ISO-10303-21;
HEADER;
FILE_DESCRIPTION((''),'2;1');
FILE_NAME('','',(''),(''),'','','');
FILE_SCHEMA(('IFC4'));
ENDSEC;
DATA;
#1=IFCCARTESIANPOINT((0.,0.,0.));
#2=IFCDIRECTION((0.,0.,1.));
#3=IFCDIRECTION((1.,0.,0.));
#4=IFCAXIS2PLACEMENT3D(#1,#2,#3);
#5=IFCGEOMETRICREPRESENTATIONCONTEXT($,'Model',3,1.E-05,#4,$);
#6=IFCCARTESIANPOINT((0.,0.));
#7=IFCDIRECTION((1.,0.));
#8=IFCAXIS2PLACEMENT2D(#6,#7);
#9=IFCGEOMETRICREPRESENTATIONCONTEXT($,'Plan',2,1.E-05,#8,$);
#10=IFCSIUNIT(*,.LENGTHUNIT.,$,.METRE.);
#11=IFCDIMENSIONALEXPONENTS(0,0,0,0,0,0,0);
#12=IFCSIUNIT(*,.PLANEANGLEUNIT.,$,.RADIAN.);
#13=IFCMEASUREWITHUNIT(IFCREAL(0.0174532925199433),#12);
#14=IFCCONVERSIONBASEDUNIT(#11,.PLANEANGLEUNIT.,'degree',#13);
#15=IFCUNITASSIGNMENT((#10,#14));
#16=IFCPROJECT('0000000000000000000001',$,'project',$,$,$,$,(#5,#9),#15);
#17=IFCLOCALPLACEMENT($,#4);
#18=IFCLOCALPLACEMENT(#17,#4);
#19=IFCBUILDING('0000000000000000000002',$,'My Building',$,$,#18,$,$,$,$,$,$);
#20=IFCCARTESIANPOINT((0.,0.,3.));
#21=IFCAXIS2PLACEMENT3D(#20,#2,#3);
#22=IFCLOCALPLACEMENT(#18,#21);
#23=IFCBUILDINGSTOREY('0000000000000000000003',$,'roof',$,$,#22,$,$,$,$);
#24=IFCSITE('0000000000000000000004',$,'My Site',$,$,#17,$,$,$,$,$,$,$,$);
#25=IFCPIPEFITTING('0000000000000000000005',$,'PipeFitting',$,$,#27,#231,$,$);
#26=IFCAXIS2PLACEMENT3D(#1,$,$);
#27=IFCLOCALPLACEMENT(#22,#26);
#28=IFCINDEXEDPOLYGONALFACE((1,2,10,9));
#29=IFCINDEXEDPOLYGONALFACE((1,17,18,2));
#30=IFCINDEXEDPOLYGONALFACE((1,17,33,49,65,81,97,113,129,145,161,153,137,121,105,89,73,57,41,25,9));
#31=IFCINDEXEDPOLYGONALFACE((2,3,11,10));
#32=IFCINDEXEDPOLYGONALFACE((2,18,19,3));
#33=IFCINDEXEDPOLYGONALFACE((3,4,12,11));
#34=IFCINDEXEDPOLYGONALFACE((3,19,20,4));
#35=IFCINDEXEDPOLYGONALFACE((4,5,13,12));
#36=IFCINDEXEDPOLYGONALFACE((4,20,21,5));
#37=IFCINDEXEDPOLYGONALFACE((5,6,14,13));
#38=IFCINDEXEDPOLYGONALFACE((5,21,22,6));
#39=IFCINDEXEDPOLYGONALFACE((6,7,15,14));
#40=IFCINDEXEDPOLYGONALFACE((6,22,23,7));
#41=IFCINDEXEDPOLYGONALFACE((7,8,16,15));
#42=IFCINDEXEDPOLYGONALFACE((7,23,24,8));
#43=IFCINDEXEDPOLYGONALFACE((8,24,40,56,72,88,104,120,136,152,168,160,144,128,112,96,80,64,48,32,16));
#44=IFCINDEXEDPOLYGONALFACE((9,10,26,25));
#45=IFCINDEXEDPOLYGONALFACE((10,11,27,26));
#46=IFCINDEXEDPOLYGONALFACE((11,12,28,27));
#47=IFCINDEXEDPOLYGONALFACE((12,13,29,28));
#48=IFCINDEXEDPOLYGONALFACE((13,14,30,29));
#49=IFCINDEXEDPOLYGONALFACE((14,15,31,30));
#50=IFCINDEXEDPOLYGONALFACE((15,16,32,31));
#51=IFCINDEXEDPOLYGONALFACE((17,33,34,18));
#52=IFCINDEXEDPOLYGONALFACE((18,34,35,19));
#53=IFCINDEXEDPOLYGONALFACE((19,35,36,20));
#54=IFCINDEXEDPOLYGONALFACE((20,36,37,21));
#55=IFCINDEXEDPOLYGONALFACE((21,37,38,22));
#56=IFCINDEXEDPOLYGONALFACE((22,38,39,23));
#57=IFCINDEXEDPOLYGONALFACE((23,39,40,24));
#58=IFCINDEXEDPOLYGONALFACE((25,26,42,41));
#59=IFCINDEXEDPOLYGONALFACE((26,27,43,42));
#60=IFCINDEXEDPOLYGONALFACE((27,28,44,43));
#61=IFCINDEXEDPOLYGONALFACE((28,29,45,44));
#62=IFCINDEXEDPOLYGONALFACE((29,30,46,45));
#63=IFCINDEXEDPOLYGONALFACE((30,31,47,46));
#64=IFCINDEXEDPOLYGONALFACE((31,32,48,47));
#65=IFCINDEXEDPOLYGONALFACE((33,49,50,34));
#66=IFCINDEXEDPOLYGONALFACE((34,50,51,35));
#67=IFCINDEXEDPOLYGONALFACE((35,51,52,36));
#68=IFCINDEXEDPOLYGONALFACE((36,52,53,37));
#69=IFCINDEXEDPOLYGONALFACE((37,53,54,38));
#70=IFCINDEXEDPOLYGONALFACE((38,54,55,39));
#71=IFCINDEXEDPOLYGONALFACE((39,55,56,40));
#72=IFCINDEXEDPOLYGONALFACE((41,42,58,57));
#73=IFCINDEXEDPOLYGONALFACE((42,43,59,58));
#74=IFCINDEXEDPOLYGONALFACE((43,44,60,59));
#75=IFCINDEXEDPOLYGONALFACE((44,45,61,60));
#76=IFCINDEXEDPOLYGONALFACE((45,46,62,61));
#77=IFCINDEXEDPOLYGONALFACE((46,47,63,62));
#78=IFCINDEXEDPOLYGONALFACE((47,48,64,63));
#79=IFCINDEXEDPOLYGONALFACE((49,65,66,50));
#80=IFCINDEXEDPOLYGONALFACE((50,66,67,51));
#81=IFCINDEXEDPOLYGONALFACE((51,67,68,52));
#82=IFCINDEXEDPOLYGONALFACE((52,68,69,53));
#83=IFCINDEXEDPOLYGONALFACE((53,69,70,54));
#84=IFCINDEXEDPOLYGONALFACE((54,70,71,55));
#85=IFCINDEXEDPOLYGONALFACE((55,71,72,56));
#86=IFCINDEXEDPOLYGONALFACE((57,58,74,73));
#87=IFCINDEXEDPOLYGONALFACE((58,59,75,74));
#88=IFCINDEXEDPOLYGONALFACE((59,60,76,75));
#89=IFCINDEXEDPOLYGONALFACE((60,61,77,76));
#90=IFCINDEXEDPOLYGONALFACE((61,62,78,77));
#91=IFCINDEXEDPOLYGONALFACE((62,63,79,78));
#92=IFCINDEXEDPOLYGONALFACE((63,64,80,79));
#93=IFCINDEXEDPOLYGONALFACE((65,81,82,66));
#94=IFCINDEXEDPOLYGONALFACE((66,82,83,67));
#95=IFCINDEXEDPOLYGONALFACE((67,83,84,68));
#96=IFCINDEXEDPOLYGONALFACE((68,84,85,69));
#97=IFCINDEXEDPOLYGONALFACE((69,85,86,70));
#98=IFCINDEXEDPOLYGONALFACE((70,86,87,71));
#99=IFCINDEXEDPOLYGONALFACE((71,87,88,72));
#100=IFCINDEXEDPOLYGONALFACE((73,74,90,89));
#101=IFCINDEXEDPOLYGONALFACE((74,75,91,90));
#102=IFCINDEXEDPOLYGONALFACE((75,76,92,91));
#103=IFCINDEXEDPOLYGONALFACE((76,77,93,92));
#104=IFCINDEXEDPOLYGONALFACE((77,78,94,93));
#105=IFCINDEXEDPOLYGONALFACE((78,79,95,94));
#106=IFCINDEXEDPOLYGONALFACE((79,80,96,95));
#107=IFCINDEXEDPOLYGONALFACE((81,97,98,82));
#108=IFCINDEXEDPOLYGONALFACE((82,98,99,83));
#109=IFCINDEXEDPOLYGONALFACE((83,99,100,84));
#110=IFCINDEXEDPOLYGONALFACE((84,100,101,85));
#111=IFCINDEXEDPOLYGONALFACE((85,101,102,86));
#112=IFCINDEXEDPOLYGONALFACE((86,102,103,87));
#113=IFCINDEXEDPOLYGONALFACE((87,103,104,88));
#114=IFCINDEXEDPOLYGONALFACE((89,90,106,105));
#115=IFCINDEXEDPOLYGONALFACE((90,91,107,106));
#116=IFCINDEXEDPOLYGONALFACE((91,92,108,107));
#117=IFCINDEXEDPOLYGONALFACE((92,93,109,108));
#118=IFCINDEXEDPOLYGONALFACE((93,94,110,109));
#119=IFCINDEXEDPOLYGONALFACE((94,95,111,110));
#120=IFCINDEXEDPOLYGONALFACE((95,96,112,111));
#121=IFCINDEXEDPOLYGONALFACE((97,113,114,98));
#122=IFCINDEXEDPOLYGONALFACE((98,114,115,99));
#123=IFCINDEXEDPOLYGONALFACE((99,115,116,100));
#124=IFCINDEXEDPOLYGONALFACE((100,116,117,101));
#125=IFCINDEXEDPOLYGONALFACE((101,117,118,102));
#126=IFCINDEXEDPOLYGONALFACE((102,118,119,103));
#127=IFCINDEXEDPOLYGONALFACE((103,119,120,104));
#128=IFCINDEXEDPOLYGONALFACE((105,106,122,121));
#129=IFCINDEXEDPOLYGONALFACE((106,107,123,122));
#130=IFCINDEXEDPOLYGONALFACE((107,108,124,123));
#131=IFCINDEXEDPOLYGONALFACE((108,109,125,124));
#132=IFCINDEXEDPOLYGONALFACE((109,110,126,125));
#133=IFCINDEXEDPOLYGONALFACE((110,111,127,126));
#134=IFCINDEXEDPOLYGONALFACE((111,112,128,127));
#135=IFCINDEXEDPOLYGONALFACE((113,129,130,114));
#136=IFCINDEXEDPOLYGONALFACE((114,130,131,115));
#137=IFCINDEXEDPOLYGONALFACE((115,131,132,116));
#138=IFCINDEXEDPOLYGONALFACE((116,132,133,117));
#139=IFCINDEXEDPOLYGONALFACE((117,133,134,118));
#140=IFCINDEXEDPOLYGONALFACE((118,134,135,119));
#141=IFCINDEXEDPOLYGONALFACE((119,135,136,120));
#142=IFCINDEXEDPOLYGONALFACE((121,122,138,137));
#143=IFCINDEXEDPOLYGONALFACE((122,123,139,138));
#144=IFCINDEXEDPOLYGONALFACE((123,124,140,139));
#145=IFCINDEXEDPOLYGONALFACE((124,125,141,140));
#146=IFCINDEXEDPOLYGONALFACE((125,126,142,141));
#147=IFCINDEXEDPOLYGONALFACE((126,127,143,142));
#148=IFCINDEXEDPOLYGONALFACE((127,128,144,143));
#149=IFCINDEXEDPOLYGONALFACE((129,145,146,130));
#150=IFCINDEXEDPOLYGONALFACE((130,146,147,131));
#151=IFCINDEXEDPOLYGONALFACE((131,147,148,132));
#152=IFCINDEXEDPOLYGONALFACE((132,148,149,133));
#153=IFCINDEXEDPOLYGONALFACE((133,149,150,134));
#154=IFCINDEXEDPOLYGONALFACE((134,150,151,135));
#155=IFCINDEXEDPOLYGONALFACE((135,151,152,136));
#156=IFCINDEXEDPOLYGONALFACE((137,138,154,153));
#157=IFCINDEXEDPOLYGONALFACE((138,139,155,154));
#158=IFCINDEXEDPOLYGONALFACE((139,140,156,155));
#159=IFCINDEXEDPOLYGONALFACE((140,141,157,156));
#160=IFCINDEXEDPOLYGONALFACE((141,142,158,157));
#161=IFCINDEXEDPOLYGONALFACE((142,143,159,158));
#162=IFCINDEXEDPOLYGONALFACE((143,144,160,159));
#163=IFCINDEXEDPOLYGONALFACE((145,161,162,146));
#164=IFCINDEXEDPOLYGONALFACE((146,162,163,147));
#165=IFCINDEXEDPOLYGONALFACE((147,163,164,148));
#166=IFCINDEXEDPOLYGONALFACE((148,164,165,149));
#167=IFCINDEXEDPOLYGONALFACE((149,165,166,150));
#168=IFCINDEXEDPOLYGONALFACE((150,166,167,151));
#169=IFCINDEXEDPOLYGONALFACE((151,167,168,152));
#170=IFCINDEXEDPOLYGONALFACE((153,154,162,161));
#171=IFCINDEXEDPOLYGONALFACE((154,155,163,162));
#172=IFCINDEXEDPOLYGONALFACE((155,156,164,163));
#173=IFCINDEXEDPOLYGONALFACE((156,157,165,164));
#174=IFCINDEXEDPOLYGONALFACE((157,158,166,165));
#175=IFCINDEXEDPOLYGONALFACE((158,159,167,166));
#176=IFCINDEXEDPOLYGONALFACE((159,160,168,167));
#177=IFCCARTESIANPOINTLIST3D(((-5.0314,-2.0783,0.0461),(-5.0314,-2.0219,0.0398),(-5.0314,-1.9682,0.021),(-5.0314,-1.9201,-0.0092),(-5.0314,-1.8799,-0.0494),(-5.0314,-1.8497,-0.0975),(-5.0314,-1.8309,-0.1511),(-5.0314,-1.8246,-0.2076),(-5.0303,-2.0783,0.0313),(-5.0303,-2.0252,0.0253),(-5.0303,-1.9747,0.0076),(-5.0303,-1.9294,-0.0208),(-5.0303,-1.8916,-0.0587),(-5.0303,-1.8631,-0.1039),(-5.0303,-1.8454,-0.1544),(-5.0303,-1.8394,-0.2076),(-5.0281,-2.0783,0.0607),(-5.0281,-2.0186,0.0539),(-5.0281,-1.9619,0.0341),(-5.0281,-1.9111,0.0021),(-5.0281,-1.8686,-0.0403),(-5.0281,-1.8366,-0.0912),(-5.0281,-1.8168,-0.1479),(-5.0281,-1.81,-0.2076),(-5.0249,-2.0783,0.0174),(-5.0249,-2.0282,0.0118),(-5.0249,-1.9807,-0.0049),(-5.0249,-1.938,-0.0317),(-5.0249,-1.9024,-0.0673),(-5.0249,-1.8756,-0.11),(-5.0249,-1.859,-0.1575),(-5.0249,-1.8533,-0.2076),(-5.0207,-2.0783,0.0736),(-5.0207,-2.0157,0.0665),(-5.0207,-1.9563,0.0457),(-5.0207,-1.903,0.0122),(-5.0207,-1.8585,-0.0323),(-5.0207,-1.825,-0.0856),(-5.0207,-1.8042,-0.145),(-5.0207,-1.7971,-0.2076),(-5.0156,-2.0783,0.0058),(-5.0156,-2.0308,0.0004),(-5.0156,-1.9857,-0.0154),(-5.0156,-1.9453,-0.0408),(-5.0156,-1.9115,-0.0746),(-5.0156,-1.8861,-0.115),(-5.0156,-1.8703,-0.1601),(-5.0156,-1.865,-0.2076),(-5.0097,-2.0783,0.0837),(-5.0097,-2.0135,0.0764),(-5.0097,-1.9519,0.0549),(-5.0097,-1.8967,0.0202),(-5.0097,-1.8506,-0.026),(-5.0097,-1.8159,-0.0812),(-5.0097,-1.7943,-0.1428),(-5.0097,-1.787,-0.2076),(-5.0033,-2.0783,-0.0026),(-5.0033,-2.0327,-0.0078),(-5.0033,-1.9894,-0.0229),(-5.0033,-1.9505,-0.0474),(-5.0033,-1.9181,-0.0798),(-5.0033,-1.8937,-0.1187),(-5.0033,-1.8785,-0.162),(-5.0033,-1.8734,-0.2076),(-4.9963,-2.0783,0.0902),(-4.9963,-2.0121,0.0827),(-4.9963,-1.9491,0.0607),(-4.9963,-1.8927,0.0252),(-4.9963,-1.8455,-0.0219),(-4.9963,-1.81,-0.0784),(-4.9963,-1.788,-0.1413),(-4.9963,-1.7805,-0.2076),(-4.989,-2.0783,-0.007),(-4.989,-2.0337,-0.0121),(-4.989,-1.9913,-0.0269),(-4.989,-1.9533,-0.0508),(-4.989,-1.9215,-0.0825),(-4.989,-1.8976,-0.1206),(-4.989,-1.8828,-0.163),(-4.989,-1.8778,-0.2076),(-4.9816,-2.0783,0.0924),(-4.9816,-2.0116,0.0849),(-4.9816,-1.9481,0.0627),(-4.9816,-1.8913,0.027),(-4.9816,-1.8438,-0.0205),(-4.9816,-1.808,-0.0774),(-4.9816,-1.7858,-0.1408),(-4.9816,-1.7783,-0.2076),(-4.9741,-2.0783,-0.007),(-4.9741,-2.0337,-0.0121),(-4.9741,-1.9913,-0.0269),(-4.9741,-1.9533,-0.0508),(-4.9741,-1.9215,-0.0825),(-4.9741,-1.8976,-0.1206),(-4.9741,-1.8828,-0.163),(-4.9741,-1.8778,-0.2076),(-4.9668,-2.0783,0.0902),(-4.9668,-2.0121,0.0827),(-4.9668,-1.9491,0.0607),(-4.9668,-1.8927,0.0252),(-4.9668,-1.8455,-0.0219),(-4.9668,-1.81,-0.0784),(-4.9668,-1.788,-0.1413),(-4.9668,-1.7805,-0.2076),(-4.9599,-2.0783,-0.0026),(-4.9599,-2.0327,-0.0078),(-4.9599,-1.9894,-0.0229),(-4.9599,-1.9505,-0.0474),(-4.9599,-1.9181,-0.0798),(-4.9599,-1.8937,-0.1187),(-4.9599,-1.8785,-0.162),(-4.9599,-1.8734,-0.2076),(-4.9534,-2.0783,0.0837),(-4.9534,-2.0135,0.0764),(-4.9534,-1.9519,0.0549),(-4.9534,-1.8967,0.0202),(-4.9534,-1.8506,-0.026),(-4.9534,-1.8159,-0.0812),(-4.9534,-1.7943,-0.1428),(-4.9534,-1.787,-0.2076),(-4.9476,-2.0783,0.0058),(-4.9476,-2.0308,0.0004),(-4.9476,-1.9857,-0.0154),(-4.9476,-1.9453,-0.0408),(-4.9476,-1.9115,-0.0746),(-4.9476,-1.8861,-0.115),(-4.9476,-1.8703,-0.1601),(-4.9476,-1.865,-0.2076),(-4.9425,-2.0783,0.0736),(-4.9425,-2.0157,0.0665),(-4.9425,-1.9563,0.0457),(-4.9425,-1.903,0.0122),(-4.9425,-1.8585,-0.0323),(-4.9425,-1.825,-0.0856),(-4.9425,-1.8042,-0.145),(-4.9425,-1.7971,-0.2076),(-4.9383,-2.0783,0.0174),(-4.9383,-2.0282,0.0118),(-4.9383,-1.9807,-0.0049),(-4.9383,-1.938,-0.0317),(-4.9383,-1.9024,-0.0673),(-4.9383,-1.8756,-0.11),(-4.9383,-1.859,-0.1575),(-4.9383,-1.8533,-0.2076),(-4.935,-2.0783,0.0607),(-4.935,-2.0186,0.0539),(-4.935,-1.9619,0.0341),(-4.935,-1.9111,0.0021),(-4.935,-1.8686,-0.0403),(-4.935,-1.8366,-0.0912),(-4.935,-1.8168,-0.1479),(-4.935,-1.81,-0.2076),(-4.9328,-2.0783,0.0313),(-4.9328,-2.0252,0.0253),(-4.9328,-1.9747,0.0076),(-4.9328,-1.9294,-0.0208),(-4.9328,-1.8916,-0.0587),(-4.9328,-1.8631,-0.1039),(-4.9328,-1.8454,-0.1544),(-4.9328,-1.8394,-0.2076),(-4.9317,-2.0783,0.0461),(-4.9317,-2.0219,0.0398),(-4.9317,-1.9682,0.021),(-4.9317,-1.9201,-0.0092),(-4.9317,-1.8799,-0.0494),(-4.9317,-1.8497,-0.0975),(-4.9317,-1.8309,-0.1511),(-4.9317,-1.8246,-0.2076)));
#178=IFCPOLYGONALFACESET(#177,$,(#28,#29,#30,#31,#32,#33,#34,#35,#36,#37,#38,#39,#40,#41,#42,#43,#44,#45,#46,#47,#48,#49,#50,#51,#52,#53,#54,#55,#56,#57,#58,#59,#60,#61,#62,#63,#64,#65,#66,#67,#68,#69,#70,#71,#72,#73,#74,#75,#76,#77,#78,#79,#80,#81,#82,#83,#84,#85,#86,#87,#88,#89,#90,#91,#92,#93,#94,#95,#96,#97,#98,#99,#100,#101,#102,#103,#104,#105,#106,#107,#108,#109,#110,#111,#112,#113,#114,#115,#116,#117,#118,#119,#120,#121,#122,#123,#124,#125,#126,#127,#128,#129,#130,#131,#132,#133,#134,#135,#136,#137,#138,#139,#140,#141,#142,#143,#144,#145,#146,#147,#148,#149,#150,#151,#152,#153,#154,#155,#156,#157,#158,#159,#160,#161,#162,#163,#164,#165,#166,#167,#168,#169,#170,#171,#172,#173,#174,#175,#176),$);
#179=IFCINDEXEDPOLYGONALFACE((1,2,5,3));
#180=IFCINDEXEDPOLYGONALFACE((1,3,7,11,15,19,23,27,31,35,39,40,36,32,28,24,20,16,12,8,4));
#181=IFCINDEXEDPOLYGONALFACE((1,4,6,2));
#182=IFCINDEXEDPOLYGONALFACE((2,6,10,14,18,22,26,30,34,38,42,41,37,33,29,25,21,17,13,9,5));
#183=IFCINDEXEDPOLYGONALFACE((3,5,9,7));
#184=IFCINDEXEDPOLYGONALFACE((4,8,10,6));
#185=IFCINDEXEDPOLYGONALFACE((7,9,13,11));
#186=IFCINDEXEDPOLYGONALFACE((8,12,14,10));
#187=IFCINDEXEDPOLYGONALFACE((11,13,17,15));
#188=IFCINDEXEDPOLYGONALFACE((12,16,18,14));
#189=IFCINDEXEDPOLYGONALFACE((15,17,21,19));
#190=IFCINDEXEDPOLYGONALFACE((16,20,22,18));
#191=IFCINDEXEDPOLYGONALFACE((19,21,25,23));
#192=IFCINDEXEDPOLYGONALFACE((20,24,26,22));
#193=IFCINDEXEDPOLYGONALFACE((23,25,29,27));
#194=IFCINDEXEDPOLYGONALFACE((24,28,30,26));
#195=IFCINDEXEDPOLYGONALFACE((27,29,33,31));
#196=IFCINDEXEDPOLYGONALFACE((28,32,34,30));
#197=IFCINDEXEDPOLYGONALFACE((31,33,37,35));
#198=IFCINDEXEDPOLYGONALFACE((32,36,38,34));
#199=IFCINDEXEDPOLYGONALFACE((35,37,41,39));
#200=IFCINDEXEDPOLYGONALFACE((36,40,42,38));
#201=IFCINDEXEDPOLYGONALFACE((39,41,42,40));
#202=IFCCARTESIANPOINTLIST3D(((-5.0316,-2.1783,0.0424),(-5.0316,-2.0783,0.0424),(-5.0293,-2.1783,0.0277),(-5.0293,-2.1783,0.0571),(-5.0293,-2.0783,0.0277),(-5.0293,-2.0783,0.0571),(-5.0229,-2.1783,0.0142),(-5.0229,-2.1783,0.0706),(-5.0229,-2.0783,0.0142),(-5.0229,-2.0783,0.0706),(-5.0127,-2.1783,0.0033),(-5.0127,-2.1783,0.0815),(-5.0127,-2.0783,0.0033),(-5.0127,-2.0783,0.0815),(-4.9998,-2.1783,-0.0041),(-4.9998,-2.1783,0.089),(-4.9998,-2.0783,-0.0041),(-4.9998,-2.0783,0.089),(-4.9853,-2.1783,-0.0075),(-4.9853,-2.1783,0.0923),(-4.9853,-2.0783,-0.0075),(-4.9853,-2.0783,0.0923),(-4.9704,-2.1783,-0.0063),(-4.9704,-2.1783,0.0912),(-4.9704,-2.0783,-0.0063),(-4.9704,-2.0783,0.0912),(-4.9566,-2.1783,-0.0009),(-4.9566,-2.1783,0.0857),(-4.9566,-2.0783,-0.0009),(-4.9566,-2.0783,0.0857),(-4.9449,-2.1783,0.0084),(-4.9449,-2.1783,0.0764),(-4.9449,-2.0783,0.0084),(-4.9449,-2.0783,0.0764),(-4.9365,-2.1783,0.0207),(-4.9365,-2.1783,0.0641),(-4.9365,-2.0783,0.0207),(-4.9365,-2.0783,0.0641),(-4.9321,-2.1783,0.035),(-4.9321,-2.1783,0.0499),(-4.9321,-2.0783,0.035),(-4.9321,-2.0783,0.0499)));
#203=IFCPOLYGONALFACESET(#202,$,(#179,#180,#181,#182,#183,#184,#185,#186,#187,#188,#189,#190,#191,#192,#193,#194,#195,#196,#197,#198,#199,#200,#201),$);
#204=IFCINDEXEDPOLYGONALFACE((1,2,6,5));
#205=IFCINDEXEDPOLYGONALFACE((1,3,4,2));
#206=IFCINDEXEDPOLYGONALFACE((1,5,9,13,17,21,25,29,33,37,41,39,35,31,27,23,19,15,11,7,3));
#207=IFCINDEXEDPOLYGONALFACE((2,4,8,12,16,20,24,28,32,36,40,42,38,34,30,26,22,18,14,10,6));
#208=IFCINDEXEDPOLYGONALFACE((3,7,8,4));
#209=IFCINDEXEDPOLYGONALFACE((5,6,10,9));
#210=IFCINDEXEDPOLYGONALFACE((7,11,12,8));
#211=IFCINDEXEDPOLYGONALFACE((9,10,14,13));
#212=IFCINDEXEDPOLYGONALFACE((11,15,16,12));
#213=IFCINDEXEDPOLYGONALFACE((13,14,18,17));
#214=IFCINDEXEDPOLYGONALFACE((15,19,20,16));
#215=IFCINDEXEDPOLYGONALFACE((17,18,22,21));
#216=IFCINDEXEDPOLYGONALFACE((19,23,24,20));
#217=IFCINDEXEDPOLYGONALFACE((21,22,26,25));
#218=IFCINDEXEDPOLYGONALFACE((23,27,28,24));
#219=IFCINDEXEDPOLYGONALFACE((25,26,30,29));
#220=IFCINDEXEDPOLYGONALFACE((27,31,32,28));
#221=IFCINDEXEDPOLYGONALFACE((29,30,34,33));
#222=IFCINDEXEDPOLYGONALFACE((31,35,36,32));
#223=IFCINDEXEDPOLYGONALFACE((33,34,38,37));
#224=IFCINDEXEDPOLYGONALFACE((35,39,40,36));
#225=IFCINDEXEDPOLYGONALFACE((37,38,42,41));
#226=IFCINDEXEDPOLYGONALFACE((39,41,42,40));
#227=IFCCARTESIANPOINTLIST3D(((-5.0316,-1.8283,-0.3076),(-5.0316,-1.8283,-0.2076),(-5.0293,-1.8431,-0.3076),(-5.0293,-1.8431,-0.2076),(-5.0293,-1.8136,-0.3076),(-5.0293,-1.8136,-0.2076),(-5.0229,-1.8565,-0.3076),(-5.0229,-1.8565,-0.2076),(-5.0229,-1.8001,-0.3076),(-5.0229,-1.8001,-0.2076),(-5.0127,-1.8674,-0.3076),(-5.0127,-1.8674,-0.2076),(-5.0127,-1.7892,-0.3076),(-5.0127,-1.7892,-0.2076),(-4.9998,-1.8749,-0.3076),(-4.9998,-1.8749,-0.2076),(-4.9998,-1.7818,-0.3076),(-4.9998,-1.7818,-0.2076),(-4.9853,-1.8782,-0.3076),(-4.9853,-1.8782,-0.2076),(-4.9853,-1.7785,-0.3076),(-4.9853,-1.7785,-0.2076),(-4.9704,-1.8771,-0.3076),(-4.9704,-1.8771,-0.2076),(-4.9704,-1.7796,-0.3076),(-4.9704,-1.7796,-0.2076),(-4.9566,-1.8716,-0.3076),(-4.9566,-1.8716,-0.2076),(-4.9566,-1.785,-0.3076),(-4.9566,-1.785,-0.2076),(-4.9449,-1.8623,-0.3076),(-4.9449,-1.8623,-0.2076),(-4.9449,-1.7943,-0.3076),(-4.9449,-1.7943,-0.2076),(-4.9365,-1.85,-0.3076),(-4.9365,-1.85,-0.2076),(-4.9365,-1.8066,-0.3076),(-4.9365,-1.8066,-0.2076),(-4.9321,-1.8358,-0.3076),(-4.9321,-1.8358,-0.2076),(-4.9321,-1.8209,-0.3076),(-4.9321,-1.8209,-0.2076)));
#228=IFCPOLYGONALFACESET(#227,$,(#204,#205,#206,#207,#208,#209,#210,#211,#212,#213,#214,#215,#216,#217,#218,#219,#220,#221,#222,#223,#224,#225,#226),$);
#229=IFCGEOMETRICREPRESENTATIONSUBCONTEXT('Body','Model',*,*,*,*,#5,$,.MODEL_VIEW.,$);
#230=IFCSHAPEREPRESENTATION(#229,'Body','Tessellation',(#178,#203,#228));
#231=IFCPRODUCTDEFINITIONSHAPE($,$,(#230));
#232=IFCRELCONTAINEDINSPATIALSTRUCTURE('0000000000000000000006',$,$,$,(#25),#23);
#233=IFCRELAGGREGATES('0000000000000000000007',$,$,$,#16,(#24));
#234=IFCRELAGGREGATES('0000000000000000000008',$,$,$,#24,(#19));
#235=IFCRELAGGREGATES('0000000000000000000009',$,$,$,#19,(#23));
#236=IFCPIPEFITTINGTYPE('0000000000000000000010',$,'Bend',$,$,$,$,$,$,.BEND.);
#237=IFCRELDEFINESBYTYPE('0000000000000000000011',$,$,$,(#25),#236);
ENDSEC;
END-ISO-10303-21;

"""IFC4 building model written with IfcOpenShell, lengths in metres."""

from ifc_helpers import new_model, entity, si_unit, converted_unit, frame, origin_with_axes, origin_2d_with_axis, place, context, subcontext, project, spatial, circle, extrude, source, transform, mapped, type_object, type_shapes, element, save


model = new_model("IFC4")

# Units and contexts
model_context = context("Model", 3, precision=1e-05, world=origin_with_axes())
plan_context = context("Plan", 2, precision=1e-05, world=origin_2d_with_axis())
body_context = subcontext(model_context, "Body", "Model", "MODEL_VIEW")
ifc_project = project(units=[si_unit("LENGTHUNIT", "METRE"), converted_unit("PLANEANGLEUNIT", "degree", entity("IfcReal", 0.0174532925199433), si_unit("PLANEANGLEUNIT", "RADIAN"), dimensions=[0, 0, 0, 0, 0, 0, 0])], contexts=[model_context, plan_context])

# Site, building, storey
site_placement = place(None, origin_with_axes())
site = spatial("IfcSite", under=ifc_project, at=site_placement, Name="My Site")
building_placement = place(site_placement, origin_with_axes())
building = spatial("IfcBuilding", under=site, at=building_placement, Name="My Building")
storey_placement = place(building_placement, frame((0.0, 0.0, 3.0), z_axis=(0.0, 0.0, 1.0), x_axis=(1.0, 0.0, 0.0)))
storey = spatial("IfcBuildingStorey", under=building, at=storey_placement, Name="roof")

# Pipe fitting
pipe_fitting_type_1 = type_object("IfcPipeFittingType", Name="Bend", PredefinedType="BEND")
shared_shape_1 = source(origin_with_axes(), body_context, "Body", "SolidModel", [
    entity("IfcSweptDiskSolid", entity("IfcIndexedPolyCurve", entity("IfcCartesianPointList3D", [[0.0, 0.0, 0.1], [0.0, -0.0732, 0.2768], [0.0, -0.25, 0.35]]), [entity("IfcArcIndex", [1, 2, 3])]), 0.05),
    extrude(circle(Radius=0.05), origin_with_axes(), (0.0, 0.0, 1.0), 0.1),
    extrude(circle(Radius=0.05), frame((0.0, -0.25, 0.35), z_axis=(0.0, -1.0, 0.000008), x_axis=(1.0, 0.0, 0.0)), (0.0, 0.0, 1.0), 0.1),
])
type_shapes(pipe_fitting_type_1, [shared_shape_1])
for number, where, z_axis, x_axis, name in (
    (1, (-4.9816, -2.1783, 0.0424), (0.0, 1.0, -0.000008), (-1.0, 0.0, 0.0), "PipeFitting"),
):
    element("IfcPipeFitting", number, at=place(storey_placement, frame(where, z_axis=z_axis, x_axis=x_axis)), inside=storey, type_object=pipe_fitting_type_1, Name=name, context=body_context, shape_type="MappedRepresentation", body=[
        mapped(shared_shape_1, transform((0.0, 0.0, 0.0), x_axis=(1.0, 0.0, 0.0), y_axis=(0.0, 1.0, 0.0), z_axis=(0.0, 0.0, 1.0), scale=1.0)),
    ])

save(model, "model.ifc")
